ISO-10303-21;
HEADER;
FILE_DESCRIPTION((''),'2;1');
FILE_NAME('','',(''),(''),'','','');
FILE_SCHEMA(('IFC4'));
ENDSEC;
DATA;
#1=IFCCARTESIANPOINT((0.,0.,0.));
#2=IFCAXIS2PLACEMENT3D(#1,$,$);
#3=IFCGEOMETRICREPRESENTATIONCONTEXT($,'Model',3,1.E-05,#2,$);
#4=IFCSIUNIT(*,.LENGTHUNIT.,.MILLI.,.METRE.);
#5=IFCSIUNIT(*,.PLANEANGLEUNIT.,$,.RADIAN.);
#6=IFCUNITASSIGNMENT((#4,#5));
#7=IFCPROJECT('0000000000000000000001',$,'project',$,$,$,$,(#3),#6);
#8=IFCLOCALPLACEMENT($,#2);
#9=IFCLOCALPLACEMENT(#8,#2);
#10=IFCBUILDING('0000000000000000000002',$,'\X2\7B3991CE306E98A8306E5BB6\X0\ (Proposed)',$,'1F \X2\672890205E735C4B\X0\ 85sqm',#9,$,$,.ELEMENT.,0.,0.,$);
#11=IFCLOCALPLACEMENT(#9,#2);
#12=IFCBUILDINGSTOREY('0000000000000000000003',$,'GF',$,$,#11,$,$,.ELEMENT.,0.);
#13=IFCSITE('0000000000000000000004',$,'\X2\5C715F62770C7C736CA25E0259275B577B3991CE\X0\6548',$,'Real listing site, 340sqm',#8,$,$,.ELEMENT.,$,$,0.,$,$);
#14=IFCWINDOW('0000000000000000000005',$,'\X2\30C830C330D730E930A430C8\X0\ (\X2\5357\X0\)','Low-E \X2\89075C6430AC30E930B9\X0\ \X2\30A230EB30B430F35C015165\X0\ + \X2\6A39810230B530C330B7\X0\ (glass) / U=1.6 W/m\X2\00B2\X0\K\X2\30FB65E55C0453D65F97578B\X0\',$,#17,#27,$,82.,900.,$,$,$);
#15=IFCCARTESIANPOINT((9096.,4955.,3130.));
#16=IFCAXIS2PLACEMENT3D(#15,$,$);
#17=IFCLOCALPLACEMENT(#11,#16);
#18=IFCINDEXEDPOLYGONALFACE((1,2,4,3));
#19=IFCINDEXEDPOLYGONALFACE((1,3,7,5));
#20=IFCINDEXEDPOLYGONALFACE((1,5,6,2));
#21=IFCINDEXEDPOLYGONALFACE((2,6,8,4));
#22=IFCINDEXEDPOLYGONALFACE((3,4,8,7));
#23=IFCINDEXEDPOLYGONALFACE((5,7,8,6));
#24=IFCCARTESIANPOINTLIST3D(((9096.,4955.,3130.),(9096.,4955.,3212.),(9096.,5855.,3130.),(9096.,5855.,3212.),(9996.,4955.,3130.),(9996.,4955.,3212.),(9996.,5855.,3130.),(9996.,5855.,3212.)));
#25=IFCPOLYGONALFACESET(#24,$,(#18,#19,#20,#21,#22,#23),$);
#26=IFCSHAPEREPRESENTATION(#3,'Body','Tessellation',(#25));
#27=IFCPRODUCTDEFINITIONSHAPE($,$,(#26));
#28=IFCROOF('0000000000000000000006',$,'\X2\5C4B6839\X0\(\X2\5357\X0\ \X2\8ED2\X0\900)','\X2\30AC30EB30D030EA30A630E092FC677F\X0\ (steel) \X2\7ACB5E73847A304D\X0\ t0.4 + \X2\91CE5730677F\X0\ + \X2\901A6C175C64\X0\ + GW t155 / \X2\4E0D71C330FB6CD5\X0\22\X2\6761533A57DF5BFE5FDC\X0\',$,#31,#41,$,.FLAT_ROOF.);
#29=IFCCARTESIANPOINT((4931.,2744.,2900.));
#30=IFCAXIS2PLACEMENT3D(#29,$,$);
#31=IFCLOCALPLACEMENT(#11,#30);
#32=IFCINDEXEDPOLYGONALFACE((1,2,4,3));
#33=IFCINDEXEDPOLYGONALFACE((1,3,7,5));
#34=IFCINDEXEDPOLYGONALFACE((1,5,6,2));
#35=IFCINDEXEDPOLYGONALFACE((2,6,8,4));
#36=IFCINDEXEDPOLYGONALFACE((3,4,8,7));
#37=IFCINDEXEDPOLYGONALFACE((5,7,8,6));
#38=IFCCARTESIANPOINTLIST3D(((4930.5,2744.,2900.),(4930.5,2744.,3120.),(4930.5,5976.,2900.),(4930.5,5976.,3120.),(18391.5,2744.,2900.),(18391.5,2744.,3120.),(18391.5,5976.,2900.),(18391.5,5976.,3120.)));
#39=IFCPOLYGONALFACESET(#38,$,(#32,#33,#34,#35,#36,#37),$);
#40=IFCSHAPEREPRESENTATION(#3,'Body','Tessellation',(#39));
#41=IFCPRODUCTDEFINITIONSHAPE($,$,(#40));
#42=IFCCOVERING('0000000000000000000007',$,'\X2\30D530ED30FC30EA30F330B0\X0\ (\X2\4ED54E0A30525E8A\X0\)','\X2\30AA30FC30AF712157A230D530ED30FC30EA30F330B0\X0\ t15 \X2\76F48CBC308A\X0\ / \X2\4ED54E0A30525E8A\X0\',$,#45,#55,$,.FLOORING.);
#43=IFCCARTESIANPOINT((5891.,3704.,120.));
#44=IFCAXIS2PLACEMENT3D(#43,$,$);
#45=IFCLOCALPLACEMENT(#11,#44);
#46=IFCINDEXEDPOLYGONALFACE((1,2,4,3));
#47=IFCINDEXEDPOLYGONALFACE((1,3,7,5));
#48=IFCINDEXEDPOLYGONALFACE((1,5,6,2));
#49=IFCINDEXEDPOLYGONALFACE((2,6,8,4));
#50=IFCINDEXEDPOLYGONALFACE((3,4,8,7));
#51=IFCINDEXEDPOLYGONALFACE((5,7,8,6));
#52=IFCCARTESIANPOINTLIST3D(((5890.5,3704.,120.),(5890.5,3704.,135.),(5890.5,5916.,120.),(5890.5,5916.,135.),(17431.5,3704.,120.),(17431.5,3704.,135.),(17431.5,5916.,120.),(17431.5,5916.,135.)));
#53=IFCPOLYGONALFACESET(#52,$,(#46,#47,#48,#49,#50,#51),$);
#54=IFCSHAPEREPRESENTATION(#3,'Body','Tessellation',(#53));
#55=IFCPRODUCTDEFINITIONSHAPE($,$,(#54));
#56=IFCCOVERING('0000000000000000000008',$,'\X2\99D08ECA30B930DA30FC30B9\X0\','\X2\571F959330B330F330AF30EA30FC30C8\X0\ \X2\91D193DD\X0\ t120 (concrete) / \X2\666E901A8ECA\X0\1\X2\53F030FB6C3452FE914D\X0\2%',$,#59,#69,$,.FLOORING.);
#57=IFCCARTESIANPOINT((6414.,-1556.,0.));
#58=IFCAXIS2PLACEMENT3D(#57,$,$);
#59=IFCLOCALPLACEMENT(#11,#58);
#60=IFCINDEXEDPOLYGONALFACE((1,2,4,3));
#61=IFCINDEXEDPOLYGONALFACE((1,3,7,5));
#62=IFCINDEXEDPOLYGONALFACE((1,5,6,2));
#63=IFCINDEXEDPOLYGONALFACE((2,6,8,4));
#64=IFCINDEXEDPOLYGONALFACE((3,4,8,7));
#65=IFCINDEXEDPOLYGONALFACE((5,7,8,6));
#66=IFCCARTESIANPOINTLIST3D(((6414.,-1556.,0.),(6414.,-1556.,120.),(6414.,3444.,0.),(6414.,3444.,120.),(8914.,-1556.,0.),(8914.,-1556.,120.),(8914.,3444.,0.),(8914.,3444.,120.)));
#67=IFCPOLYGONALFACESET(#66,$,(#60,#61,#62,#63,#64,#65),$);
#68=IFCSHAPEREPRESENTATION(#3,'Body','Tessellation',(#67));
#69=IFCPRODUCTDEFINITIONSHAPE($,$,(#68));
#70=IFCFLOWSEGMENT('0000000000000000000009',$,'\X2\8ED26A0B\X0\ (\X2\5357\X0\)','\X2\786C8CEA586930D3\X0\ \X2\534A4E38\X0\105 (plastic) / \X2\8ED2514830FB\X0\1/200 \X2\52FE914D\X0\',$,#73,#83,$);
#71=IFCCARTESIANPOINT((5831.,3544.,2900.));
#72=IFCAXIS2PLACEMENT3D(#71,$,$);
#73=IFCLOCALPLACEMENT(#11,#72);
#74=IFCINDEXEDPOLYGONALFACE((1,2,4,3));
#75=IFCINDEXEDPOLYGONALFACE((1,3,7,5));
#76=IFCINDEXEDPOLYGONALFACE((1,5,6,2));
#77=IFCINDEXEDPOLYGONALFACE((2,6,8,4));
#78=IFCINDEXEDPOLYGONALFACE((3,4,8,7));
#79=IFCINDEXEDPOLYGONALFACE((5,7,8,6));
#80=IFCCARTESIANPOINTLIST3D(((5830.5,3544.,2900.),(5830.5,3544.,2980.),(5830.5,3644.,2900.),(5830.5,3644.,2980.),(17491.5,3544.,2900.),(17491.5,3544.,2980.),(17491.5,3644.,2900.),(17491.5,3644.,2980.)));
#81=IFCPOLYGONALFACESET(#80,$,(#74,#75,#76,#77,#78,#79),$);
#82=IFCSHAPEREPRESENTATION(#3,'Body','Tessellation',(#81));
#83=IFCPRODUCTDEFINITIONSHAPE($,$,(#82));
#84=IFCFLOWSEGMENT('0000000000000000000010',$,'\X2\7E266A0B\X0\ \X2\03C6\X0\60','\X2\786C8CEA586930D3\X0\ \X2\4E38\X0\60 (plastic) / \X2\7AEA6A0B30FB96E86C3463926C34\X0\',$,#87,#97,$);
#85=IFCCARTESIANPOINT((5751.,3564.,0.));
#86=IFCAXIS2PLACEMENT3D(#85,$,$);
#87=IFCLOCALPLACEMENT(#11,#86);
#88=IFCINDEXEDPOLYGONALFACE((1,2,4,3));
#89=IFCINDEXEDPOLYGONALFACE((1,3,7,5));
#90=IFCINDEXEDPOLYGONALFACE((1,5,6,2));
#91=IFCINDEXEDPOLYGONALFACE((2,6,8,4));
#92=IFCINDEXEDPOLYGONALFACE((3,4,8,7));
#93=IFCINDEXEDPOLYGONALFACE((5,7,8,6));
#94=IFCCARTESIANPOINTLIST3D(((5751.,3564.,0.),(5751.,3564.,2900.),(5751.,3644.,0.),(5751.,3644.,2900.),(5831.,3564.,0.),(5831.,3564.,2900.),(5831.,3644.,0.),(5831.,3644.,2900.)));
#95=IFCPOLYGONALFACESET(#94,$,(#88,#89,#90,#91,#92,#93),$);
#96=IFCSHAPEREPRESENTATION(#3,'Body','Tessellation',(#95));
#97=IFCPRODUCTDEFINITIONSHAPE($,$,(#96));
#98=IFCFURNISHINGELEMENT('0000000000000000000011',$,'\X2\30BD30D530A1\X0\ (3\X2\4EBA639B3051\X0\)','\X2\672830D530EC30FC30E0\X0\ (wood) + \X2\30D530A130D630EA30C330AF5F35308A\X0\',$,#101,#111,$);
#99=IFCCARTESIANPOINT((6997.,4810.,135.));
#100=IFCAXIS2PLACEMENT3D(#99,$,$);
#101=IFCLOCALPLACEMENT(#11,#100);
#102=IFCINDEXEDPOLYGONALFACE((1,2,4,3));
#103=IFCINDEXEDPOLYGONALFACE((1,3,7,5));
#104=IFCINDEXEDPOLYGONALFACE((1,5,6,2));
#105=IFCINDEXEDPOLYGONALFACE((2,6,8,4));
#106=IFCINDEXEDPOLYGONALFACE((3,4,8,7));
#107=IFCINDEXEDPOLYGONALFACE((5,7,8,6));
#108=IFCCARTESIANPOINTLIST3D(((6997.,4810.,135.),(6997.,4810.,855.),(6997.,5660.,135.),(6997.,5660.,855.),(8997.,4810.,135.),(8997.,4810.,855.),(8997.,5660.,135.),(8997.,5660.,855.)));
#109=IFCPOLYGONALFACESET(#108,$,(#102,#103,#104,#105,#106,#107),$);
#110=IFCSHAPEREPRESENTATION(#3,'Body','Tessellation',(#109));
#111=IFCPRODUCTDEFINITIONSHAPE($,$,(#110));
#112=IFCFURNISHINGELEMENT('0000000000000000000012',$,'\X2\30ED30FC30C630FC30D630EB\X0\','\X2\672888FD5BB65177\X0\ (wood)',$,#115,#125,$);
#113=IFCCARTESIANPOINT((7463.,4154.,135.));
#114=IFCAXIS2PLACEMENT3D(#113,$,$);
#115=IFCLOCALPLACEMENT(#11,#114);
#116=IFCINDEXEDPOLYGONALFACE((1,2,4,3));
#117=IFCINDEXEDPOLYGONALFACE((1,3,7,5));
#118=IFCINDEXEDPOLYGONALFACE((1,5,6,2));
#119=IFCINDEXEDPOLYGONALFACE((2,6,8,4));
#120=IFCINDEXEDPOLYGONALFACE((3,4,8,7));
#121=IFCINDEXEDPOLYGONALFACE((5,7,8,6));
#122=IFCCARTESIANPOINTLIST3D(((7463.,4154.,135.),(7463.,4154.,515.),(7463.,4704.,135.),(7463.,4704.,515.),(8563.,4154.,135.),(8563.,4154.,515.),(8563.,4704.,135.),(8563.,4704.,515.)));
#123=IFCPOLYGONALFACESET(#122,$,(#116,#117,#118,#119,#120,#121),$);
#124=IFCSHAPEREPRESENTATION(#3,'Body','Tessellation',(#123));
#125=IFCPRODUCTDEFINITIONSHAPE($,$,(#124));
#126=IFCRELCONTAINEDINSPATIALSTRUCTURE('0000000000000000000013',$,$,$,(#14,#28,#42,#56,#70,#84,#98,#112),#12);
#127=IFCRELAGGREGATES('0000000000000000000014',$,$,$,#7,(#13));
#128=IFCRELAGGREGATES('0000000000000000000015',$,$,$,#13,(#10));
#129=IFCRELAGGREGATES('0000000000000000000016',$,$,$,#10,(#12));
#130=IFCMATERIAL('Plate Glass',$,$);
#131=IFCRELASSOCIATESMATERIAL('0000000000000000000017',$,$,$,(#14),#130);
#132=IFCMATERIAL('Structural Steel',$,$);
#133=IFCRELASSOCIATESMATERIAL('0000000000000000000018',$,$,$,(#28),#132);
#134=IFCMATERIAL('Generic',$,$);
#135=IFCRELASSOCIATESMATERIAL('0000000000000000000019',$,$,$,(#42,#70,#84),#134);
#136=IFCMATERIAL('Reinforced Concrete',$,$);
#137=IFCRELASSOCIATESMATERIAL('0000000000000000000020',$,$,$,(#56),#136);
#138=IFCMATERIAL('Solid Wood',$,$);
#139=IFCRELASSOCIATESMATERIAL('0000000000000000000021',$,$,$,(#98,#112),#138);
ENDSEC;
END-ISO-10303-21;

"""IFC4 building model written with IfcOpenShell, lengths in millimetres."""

from ifc_helpers import new_model, si_unit, frame, frame_2d, origin, place, context, project, spatial, rectangle, extrude, material, element, save


model = new_model("IFC4")

# Units and contexts
model_context = context("Model", 3, precision=1e-05, world=origin())
ifc_project = project(units=[si_unit("LENGTHUNIT", "METRE", prefix="MILLI"), si_unit("PLANEANGLEUNIT", "RADIAN")], contexts=[model_context])

# Site, building, storey
site_placement = place(None, origin())
site = spatial("IfcSite", under=ifc_project, at=site_placement, Name="山形県米沢市大字笹野6548", ObjectType="Real listing site, 340sqm", CompositionType="ELEMENT", RefElevation=0.0)
building_placement = place(site_placement, origin())
building = spatial("IfcBuilding", under=site, at=building_placement, Name="笹野の風の家 (Proposed)", ObjectType="1F 木造平屋 85sqm", CompositionType="ELEMENT", ElevationOfRefHeight=0.0, ElevationOfTerrain=0.0)
storey_placement = place(building_placement, origin())
storey = spatial("IfcBuildingStorey", under=building, at=storey_placement, Name="GF", CompositionType="ELEMENT", Elevation=0.0)

# Shared definitions
ifc_material_1 = material(Name="Solid Wood")

# Shared definitions
ifc_material_2 = material(Name="Reinforced Concrete")

# Shared definitions
ifc_material_3 = material(Name="Plate Glass")

# Window
window_1_placement = place(storey_placement, frame((9096.0, 4955.0, 3130.0)))
element("IfcWindow", 1, at=window_1_placement, inside=storey, material=ifc_material_3, Name="トップライト (南)", Description="Low-E 複層ガラス アルゴン封入 + 樹脂サッシ (glass) / U=1.6 W/m²K・日射取得型", OverallHeight=82.0, OverallWidth=900.0, context=model_context, shape_type="SweptSolid", body=[
    extrude(rectangle(XDim=900.0, YDim=900.0, at=frame_2d((450.0, 450.0))), frame((9096.0, 4955.0, 3130.0)), (0.0, 0.0, 1.0), 82.0),
])

# Roof
ifc_material_4 = material(Name="Structural Steel")
roof_1_placement = place(storey_placement, frame((4931.0, 2744.0, 2900.0)))
element("IfcRoof", 2, at=roof_1_placement, inside=storey, material=ifc_material_4, Name="屋根(南 軒900)", Description="ガルバリウム鋼板 (steel) 立平葺き t0.4 + 野地板 + 通気層 + GW t155 / 不燃・法22条区域対応", PredefinedType="FLAT_ROOF", context=model_context, shape_type="SweptSolid", body=[
    extrude(rectangle(XDim=13461.0, YDim=3232.0, at=frame_2d((6730.0, 1616.0))), frame((4931.0, 2744.0, 2900.0)), (0.0, 0.0, 1.0), 220.0),
])

# Coverings
ifc_material_5 = material(Name="Generic")
covering_1_placement = place(storey_placement, frame((5891.0, 3704.0, 120.0)))
element("IfcCovering", 3, at=covering_1_placement, inside=storey, material=ifc_material_5, Name="フローリング (仕上げ床)", Description="オーク無垢フローリング t15 直貼り / 仕上げ床", PredefinedType="FLOORING", context=model_context, shape_type="SweptSolid", body=[
    extrude(rectangle(XDim=11541.0, YDim=2212.0, at=frame_2d((5770.0, 1106.0))), frame((5891.0, 3704.0, 120.0)), (0.0, 0.0, 1.0), 15.0),
])
covering_2_placement = place(storey_placement, frame((6414.0, -1556.0, 0.0)))
element("IfcCovering", 4, at=covering_2_placement, inside=storey, material=ifc_material_2, Name="駐車スペース", Description="土間コンクリート 金鏝 t120 (concrete) / 普通車1台・水勾配2%", PredefinedType="FLOORING", context=model_context, shape_type="SweptSolid", body=[
    extrude(rectangle(XDim=2500.0, YDim=5000.0, at=frame_2d((1250.0, 2500.0))), frame((6414.0, -1556.0, 0.0)), (0.0, 0.0, 1.0), 120.0),
])

# Flow segments
flow_segment_1_placement = place(storey_placement, frame((5831.0, 3544.0, 2900.0)))
element("IfcFlowSegment", 5, at=flow_segment_1_placement, inside=storey, material=ifc_material_5, Name="軒樋 (南)", Description="硬質塩ビ 半丸105 (plastic) / 軒先・1/200 勾配", context=model_context, shape_type="SweptSolid", body=[
    extrude(rectangle(XDim=11661.0, YDim=100.0, at=frame_2d((5830.0, 50.0))), frame((5831.0, 3544.0, 2900.0)), (0.0, 0.0, 1.0), 80.0),
])
flow_segment_2_placement = place(storey_placement, frame((5751.0, 3564.0, 0.0)))
element("IfcFlowSegment", 6, at=flow_segment_2_placement, inside=storey, material=ifc_material_5, Name="縦樋 φ60", Description="硬質塩ビ 丸60 (plastic) / 竪樋・雨水排水", context=model_context, shape_type="SweptSolid", body=[
    extrude(rectangle(XDim=80.0, YDim=80.0, at=frame_2d((40.0, 40.0))), frame((5751.0, 3564.0, 0.0)), (0.0, 0.0, 1.0), 2900.0),
])

# Furnishing elements
furnishing_1_placement = place(storey_placement, frame((6997.0, 4810.0, 135.0)))
element("IfcFurnishingElement", 7, at=furnishing_1_placement, inside=storey, material=ifc_material_1, Name="ソファ (3人掛け)", Description="木フレーム (wood) + ファブリック張り", context=model_context, shape_type="SweptSolid", body=[
    extrude(rectangle(XDim=2000.0, YDim=850.0, at=frame_2d((1000.0, 425.0))), frame((6997.0, 4810.0, 135.0)), (0.0, 0.0, 1.0), 720.0),
])
furnishing_2_placement = place(storey_placement, frame((7463.0, 4154.0, 135.0)))
element("IfcFurnishingElement", 8, at=furnishing_2_placement, inside=storey, material=ifc_material_1, Name="ローテーブル", Description="木製家具 (wood)", context=model_context, shape_type="SweptSolid", body=[
    extrude(rectangle(XDim=1100.0, YDim=550.0, at=frame_2d((550.0, 275.0))), frame((7463.0, 4154.0, 135.0)), (0.0, 0.0, 1.0), 380.0),
])

save(model, "model.ifc")
